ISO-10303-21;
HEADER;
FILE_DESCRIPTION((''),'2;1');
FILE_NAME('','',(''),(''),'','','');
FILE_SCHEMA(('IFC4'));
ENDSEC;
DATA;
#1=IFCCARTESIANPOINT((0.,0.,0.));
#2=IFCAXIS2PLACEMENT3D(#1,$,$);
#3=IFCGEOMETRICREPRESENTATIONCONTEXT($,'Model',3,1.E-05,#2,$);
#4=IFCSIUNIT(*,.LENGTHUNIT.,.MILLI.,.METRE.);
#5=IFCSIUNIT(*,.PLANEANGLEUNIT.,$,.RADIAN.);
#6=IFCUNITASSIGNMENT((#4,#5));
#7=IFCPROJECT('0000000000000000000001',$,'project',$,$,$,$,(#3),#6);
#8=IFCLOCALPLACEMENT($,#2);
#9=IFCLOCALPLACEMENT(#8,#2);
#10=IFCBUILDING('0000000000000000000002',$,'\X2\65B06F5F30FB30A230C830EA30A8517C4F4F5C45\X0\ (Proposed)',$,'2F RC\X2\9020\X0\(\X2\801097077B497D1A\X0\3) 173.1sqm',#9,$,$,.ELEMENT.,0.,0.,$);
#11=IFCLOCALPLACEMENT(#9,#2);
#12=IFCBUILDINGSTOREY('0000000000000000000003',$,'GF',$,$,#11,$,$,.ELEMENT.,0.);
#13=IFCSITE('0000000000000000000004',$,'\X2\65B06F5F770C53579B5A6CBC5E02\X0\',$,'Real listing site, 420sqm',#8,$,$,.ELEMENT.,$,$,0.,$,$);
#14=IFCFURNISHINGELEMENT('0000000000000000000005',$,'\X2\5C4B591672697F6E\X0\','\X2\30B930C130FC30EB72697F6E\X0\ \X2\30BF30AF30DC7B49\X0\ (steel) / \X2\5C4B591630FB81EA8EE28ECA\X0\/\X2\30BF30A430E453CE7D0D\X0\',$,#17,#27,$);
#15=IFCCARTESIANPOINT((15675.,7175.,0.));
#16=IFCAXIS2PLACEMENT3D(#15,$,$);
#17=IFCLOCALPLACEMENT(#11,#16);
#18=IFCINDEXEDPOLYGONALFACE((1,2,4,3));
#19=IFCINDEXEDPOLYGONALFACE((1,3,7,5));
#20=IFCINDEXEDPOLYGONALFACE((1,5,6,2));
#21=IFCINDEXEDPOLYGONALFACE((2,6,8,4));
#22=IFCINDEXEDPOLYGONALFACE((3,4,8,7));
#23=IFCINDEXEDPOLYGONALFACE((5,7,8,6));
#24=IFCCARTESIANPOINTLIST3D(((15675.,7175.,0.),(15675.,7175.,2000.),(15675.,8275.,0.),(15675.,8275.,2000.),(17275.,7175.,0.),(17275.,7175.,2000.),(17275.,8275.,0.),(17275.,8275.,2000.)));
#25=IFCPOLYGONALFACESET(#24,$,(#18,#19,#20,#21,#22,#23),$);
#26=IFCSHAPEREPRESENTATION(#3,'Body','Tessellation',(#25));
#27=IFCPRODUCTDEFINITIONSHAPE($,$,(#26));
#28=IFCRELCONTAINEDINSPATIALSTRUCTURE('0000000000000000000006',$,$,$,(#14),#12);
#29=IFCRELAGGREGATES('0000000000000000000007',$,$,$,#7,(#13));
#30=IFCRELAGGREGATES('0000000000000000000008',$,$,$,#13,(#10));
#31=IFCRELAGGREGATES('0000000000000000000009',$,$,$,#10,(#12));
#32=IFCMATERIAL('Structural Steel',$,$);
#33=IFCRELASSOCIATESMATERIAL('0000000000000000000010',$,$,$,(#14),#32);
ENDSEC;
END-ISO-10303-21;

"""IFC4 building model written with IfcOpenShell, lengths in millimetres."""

from ifc_helpers import new_model, si_unit, frame, frame_2d, origin, place, context, project, spatial, rectangle, extrude, material, element, save


model = new_model("IFC4")

# Units and contexts
model_context = context("Model", 3, precision=1e-05, world=origin())
ifc_project = project(units=[si_unit("LENGTHUNIT", "METRE", prefix="MILLI"), si_unit("PLANEANGLEUNIT", "RADIAN")], contexts=[model_context])

# Site, building, storey
site_placement = place(None, origin())
site = spatial("IfcSite", under=ifc_project, at=site_placement, Name="新潟県南魚沼市", ObjectType="Real listing site, 420sqm", CompositionType="ELEMENT", RefElevation=0.0)
building_placement = place(site_placement, origin())
building = spatial("IfcBuilding", under=site, at=building_placement, Name="新潟・アトリエ兼住居 (Proposed)", ObjectType="2F RC造(耐震等級3) 173.1sqm", CompositionType="ELEMENT", ElevationOfRefHeight=0.0, ElevationOfTerrain=0.0)
storey_placement = place(building_placement, origin())
storey = spatial("IfcBuildingStorey", under=building, at=storey_placement, Name="GF", CompositionType="ELEMENT", Elevation=0.0)

# Shared definitions
ifc_material_1 = material(Name="Structural Steel")

# Furnishing element
furnishing_1_placement = place(storey_placement, frame((15675.0, 7175.0, 0.0)))
element("IfcFurnishingElement", 1, at=furnishing_1_placement, inside=storey, material=ifc_material_1, Name="屋外物置", Description="スチール物置 タクボ等 (steel) / 屋外・自転車/タイヤ収納", context=model_context, shape_type="SweptSolid", body=[
    extrude(rectangle(XDim=1600.0, YDim=1100.0, at=frame_2d((800.0, 550.0))), frame((15675.0, 7175.0, 0.0)), (0.0, 0.0, 1.0), 2000.0),
])

save(model, "model.ifc")
